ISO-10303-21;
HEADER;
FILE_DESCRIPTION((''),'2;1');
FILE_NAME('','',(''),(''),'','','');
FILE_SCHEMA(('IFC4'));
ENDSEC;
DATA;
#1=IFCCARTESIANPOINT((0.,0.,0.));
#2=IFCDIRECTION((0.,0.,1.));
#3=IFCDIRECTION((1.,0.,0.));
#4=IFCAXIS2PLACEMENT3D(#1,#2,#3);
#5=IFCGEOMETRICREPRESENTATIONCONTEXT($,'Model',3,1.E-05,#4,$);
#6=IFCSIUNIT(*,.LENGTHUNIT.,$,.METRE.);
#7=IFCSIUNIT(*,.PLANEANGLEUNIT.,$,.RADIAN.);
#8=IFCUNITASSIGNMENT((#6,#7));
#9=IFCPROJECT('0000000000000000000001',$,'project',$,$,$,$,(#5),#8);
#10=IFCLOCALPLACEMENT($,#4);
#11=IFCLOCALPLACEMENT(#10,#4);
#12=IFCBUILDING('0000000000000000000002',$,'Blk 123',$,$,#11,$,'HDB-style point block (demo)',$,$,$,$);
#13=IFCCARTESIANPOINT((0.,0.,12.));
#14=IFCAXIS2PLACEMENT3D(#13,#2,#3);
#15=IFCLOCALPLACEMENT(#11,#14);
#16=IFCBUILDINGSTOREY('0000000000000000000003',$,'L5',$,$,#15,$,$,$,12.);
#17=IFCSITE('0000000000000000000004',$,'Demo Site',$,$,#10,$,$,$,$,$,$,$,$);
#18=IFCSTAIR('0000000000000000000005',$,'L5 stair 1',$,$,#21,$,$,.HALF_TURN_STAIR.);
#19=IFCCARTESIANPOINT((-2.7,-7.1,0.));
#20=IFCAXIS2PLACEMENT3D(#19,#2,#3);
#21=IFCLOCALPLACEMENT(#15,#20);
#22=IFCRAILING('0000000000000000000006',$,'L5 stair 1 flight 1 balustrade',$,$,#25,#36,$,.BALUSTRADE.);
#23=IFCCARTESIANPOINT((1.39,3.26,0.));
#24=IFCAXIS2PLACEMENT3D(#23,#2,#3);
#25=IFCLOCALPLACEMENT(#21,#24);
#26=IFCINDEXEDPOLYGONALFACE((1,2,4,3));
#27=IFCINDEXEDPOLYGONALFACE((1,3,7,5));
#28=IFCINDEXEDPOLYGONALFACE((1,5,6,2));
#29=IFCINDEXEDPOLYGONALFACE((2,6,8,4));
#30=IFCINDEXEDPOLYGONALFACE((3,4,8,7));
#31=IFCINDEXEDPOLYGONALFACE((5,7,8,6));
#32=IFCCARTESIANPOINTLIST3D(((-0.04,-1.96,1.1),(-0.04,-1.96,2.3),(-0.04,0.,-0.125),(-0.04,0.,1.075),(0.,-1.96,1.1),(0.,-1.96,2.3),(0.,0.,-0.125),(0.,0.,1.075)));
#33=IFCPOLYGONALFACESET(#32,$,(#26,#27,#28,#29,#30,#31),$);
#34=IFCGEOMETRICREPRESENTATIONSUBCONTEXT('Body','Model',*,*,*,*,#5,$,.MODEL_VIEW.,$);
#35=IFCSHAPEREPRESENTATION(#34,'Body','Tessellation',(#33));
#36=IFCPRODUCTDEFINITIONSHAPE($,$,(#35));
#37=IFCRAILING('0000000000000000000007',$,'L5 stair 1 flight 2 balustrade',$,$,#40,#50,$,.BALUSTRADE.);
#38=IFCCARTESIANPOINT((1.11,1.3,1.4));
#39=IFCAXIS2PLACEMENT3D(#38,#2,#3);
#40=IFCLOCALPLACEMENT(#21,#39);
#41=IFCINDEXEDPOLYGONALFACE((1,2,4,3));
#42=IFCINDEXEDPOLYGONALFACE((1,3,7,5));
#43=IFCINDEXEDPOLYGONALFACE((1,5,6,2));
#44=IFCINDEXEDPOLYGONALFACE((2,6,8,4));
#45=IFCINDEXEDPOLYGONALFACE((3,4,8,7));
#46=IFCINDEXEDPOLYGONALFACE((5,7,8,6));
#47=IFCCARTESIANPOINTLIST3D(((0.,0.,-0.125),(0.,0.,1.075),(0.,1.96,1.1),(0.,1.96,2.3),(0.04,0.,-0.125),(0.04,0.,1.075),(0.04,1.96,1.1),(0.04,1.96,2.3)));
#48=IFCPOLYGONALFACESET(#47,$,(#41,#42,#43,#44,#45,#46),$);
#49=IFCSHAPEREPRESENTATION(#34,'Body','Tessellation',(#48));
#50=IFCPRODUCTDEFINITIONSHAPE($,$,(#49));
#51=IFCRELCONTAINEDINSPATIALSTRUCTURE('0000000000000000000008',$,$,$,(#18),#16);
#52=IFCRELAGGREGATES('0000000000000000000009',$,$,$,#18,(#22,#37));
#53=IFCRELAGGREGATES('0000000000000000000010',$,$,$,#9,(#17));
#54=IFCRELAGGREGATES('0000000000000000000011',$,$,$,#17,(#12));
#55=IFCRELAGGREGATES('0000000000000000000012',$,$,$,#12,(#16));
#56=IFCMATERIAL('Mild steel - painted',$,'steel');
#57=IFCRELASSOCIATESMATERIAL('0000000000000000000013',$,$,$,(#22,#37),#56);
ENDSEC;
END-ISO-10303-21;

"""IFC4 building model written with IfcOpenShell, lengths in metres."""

from ifc_helpers import new_model, si_unit, frame, origin_with_axes, place, context, subcontext, project, spatial, polyline, outline, extrude, material, element, aggregate, save


model = new_model("IFC4")

# Units and contexts
model_context = context("Model", 3, precision=1e-05, world=origin_with_axes())
body_context = subcontext(model_context, "Body", "Model", "MODEL_VIEW")
ifc_project = project(units=[si_unit("LENGTHUNIT", "METRE"), si_unit("PLANEANGLEUNIT", "RADIAN")], contexts=[model_context])

# Site, building, storey
site_placement = place(None, origin_with_axes())
site = spatial("IfcSite", under=ifc_project, at=site_placement, Name="Demo Site")
building_placement = place(site_placement, origin_with_axes())
building = spatial("IfcBuilding", under=site, at=building_placement, Name="Blk 123", LongName="HDB-style point block (demo)")
storey_placement = place(building_placement, frame((0.0, 0.0, 12.0), z_axis=(0.0, 0.0, 1.0), x_axis=(1.0, 0.0, 0.0)))
storey = spatial("IfcBuildingStorey", under=building, at=storey_placement, Name="L5", Elevation=12.0)

# Stair
stair_placement = place(storey_placement, frame((-2.7, -7.1, 0.0), z_axis=(0.0, 0.0, 1.0), x_axis=(1.0, 0.0, 0.0)))
stair = element("IfcStair", 1, at=stair_placement, inside=storey, Name="L5 stair 1", PredefinedType="HALF_TURN_STAIR")

# Railings
ifc_material_1 = material(Name="Mild steel - painted", Category="steel")
railing_1_placement = place(stair_placement, frame((1.39, 3.26, 0.0), z_axis=(0.0, 0.0, 1.0), x_axis=(1.0, 0.0, 0.0)))
railing_1 = element("IfcRailing", 2, at=railing_1_placement, material=ifc_material_1, Name="L5 stair 1 flight 1 balustrade", PredefinedType="BALUSTRADE", context=body_context, shape_type="SweptSolid", body=[
    extrude(outline(polyline([(0.0, -0.125), (1.96, 1.1), (1.96, 2.3), (0.0, 1.075), (0.0, -0.125)])), frame((0.0, 0.0, 0.0), z_axis=(-1.0, 0.0, 0.0), x_axis=(0.0, -1.0, 0.0)), (0.0, 0.0, 1.0), 0.04),
])
railing_2_placement = place(stair_placement, frame((1.11, 1.3, 1.4), z_axis=(0.0, 0.0, 1.0), x_axis=(1.0, 0.0, 0.0)))
railing_2 = element("IfcRailing", 3, at=railing_2_placement, material=ifc_material_1, Name="L5 stair 1 flight 2 balustrade", PredefinedType="BALUSTRADE", context=body_context, shape_type="SweptSolid", body=[
    extrude(outline(polyline([(0.0, -0.125), (1.96, 1.1), (1.96, 2.3), (0.0, 1.075), (0.0, -0.125)])), frame((0.0, 0.0, 0.0), z_axis=(1.0, 0.0, 0.0), x_axis=(0.0, 1.0, 0.0)), (0.0, 0.0, 1.0), 0.04),
])
aggregate(stair, [railing_1, railing_2])

save(model, "model.ifc")
